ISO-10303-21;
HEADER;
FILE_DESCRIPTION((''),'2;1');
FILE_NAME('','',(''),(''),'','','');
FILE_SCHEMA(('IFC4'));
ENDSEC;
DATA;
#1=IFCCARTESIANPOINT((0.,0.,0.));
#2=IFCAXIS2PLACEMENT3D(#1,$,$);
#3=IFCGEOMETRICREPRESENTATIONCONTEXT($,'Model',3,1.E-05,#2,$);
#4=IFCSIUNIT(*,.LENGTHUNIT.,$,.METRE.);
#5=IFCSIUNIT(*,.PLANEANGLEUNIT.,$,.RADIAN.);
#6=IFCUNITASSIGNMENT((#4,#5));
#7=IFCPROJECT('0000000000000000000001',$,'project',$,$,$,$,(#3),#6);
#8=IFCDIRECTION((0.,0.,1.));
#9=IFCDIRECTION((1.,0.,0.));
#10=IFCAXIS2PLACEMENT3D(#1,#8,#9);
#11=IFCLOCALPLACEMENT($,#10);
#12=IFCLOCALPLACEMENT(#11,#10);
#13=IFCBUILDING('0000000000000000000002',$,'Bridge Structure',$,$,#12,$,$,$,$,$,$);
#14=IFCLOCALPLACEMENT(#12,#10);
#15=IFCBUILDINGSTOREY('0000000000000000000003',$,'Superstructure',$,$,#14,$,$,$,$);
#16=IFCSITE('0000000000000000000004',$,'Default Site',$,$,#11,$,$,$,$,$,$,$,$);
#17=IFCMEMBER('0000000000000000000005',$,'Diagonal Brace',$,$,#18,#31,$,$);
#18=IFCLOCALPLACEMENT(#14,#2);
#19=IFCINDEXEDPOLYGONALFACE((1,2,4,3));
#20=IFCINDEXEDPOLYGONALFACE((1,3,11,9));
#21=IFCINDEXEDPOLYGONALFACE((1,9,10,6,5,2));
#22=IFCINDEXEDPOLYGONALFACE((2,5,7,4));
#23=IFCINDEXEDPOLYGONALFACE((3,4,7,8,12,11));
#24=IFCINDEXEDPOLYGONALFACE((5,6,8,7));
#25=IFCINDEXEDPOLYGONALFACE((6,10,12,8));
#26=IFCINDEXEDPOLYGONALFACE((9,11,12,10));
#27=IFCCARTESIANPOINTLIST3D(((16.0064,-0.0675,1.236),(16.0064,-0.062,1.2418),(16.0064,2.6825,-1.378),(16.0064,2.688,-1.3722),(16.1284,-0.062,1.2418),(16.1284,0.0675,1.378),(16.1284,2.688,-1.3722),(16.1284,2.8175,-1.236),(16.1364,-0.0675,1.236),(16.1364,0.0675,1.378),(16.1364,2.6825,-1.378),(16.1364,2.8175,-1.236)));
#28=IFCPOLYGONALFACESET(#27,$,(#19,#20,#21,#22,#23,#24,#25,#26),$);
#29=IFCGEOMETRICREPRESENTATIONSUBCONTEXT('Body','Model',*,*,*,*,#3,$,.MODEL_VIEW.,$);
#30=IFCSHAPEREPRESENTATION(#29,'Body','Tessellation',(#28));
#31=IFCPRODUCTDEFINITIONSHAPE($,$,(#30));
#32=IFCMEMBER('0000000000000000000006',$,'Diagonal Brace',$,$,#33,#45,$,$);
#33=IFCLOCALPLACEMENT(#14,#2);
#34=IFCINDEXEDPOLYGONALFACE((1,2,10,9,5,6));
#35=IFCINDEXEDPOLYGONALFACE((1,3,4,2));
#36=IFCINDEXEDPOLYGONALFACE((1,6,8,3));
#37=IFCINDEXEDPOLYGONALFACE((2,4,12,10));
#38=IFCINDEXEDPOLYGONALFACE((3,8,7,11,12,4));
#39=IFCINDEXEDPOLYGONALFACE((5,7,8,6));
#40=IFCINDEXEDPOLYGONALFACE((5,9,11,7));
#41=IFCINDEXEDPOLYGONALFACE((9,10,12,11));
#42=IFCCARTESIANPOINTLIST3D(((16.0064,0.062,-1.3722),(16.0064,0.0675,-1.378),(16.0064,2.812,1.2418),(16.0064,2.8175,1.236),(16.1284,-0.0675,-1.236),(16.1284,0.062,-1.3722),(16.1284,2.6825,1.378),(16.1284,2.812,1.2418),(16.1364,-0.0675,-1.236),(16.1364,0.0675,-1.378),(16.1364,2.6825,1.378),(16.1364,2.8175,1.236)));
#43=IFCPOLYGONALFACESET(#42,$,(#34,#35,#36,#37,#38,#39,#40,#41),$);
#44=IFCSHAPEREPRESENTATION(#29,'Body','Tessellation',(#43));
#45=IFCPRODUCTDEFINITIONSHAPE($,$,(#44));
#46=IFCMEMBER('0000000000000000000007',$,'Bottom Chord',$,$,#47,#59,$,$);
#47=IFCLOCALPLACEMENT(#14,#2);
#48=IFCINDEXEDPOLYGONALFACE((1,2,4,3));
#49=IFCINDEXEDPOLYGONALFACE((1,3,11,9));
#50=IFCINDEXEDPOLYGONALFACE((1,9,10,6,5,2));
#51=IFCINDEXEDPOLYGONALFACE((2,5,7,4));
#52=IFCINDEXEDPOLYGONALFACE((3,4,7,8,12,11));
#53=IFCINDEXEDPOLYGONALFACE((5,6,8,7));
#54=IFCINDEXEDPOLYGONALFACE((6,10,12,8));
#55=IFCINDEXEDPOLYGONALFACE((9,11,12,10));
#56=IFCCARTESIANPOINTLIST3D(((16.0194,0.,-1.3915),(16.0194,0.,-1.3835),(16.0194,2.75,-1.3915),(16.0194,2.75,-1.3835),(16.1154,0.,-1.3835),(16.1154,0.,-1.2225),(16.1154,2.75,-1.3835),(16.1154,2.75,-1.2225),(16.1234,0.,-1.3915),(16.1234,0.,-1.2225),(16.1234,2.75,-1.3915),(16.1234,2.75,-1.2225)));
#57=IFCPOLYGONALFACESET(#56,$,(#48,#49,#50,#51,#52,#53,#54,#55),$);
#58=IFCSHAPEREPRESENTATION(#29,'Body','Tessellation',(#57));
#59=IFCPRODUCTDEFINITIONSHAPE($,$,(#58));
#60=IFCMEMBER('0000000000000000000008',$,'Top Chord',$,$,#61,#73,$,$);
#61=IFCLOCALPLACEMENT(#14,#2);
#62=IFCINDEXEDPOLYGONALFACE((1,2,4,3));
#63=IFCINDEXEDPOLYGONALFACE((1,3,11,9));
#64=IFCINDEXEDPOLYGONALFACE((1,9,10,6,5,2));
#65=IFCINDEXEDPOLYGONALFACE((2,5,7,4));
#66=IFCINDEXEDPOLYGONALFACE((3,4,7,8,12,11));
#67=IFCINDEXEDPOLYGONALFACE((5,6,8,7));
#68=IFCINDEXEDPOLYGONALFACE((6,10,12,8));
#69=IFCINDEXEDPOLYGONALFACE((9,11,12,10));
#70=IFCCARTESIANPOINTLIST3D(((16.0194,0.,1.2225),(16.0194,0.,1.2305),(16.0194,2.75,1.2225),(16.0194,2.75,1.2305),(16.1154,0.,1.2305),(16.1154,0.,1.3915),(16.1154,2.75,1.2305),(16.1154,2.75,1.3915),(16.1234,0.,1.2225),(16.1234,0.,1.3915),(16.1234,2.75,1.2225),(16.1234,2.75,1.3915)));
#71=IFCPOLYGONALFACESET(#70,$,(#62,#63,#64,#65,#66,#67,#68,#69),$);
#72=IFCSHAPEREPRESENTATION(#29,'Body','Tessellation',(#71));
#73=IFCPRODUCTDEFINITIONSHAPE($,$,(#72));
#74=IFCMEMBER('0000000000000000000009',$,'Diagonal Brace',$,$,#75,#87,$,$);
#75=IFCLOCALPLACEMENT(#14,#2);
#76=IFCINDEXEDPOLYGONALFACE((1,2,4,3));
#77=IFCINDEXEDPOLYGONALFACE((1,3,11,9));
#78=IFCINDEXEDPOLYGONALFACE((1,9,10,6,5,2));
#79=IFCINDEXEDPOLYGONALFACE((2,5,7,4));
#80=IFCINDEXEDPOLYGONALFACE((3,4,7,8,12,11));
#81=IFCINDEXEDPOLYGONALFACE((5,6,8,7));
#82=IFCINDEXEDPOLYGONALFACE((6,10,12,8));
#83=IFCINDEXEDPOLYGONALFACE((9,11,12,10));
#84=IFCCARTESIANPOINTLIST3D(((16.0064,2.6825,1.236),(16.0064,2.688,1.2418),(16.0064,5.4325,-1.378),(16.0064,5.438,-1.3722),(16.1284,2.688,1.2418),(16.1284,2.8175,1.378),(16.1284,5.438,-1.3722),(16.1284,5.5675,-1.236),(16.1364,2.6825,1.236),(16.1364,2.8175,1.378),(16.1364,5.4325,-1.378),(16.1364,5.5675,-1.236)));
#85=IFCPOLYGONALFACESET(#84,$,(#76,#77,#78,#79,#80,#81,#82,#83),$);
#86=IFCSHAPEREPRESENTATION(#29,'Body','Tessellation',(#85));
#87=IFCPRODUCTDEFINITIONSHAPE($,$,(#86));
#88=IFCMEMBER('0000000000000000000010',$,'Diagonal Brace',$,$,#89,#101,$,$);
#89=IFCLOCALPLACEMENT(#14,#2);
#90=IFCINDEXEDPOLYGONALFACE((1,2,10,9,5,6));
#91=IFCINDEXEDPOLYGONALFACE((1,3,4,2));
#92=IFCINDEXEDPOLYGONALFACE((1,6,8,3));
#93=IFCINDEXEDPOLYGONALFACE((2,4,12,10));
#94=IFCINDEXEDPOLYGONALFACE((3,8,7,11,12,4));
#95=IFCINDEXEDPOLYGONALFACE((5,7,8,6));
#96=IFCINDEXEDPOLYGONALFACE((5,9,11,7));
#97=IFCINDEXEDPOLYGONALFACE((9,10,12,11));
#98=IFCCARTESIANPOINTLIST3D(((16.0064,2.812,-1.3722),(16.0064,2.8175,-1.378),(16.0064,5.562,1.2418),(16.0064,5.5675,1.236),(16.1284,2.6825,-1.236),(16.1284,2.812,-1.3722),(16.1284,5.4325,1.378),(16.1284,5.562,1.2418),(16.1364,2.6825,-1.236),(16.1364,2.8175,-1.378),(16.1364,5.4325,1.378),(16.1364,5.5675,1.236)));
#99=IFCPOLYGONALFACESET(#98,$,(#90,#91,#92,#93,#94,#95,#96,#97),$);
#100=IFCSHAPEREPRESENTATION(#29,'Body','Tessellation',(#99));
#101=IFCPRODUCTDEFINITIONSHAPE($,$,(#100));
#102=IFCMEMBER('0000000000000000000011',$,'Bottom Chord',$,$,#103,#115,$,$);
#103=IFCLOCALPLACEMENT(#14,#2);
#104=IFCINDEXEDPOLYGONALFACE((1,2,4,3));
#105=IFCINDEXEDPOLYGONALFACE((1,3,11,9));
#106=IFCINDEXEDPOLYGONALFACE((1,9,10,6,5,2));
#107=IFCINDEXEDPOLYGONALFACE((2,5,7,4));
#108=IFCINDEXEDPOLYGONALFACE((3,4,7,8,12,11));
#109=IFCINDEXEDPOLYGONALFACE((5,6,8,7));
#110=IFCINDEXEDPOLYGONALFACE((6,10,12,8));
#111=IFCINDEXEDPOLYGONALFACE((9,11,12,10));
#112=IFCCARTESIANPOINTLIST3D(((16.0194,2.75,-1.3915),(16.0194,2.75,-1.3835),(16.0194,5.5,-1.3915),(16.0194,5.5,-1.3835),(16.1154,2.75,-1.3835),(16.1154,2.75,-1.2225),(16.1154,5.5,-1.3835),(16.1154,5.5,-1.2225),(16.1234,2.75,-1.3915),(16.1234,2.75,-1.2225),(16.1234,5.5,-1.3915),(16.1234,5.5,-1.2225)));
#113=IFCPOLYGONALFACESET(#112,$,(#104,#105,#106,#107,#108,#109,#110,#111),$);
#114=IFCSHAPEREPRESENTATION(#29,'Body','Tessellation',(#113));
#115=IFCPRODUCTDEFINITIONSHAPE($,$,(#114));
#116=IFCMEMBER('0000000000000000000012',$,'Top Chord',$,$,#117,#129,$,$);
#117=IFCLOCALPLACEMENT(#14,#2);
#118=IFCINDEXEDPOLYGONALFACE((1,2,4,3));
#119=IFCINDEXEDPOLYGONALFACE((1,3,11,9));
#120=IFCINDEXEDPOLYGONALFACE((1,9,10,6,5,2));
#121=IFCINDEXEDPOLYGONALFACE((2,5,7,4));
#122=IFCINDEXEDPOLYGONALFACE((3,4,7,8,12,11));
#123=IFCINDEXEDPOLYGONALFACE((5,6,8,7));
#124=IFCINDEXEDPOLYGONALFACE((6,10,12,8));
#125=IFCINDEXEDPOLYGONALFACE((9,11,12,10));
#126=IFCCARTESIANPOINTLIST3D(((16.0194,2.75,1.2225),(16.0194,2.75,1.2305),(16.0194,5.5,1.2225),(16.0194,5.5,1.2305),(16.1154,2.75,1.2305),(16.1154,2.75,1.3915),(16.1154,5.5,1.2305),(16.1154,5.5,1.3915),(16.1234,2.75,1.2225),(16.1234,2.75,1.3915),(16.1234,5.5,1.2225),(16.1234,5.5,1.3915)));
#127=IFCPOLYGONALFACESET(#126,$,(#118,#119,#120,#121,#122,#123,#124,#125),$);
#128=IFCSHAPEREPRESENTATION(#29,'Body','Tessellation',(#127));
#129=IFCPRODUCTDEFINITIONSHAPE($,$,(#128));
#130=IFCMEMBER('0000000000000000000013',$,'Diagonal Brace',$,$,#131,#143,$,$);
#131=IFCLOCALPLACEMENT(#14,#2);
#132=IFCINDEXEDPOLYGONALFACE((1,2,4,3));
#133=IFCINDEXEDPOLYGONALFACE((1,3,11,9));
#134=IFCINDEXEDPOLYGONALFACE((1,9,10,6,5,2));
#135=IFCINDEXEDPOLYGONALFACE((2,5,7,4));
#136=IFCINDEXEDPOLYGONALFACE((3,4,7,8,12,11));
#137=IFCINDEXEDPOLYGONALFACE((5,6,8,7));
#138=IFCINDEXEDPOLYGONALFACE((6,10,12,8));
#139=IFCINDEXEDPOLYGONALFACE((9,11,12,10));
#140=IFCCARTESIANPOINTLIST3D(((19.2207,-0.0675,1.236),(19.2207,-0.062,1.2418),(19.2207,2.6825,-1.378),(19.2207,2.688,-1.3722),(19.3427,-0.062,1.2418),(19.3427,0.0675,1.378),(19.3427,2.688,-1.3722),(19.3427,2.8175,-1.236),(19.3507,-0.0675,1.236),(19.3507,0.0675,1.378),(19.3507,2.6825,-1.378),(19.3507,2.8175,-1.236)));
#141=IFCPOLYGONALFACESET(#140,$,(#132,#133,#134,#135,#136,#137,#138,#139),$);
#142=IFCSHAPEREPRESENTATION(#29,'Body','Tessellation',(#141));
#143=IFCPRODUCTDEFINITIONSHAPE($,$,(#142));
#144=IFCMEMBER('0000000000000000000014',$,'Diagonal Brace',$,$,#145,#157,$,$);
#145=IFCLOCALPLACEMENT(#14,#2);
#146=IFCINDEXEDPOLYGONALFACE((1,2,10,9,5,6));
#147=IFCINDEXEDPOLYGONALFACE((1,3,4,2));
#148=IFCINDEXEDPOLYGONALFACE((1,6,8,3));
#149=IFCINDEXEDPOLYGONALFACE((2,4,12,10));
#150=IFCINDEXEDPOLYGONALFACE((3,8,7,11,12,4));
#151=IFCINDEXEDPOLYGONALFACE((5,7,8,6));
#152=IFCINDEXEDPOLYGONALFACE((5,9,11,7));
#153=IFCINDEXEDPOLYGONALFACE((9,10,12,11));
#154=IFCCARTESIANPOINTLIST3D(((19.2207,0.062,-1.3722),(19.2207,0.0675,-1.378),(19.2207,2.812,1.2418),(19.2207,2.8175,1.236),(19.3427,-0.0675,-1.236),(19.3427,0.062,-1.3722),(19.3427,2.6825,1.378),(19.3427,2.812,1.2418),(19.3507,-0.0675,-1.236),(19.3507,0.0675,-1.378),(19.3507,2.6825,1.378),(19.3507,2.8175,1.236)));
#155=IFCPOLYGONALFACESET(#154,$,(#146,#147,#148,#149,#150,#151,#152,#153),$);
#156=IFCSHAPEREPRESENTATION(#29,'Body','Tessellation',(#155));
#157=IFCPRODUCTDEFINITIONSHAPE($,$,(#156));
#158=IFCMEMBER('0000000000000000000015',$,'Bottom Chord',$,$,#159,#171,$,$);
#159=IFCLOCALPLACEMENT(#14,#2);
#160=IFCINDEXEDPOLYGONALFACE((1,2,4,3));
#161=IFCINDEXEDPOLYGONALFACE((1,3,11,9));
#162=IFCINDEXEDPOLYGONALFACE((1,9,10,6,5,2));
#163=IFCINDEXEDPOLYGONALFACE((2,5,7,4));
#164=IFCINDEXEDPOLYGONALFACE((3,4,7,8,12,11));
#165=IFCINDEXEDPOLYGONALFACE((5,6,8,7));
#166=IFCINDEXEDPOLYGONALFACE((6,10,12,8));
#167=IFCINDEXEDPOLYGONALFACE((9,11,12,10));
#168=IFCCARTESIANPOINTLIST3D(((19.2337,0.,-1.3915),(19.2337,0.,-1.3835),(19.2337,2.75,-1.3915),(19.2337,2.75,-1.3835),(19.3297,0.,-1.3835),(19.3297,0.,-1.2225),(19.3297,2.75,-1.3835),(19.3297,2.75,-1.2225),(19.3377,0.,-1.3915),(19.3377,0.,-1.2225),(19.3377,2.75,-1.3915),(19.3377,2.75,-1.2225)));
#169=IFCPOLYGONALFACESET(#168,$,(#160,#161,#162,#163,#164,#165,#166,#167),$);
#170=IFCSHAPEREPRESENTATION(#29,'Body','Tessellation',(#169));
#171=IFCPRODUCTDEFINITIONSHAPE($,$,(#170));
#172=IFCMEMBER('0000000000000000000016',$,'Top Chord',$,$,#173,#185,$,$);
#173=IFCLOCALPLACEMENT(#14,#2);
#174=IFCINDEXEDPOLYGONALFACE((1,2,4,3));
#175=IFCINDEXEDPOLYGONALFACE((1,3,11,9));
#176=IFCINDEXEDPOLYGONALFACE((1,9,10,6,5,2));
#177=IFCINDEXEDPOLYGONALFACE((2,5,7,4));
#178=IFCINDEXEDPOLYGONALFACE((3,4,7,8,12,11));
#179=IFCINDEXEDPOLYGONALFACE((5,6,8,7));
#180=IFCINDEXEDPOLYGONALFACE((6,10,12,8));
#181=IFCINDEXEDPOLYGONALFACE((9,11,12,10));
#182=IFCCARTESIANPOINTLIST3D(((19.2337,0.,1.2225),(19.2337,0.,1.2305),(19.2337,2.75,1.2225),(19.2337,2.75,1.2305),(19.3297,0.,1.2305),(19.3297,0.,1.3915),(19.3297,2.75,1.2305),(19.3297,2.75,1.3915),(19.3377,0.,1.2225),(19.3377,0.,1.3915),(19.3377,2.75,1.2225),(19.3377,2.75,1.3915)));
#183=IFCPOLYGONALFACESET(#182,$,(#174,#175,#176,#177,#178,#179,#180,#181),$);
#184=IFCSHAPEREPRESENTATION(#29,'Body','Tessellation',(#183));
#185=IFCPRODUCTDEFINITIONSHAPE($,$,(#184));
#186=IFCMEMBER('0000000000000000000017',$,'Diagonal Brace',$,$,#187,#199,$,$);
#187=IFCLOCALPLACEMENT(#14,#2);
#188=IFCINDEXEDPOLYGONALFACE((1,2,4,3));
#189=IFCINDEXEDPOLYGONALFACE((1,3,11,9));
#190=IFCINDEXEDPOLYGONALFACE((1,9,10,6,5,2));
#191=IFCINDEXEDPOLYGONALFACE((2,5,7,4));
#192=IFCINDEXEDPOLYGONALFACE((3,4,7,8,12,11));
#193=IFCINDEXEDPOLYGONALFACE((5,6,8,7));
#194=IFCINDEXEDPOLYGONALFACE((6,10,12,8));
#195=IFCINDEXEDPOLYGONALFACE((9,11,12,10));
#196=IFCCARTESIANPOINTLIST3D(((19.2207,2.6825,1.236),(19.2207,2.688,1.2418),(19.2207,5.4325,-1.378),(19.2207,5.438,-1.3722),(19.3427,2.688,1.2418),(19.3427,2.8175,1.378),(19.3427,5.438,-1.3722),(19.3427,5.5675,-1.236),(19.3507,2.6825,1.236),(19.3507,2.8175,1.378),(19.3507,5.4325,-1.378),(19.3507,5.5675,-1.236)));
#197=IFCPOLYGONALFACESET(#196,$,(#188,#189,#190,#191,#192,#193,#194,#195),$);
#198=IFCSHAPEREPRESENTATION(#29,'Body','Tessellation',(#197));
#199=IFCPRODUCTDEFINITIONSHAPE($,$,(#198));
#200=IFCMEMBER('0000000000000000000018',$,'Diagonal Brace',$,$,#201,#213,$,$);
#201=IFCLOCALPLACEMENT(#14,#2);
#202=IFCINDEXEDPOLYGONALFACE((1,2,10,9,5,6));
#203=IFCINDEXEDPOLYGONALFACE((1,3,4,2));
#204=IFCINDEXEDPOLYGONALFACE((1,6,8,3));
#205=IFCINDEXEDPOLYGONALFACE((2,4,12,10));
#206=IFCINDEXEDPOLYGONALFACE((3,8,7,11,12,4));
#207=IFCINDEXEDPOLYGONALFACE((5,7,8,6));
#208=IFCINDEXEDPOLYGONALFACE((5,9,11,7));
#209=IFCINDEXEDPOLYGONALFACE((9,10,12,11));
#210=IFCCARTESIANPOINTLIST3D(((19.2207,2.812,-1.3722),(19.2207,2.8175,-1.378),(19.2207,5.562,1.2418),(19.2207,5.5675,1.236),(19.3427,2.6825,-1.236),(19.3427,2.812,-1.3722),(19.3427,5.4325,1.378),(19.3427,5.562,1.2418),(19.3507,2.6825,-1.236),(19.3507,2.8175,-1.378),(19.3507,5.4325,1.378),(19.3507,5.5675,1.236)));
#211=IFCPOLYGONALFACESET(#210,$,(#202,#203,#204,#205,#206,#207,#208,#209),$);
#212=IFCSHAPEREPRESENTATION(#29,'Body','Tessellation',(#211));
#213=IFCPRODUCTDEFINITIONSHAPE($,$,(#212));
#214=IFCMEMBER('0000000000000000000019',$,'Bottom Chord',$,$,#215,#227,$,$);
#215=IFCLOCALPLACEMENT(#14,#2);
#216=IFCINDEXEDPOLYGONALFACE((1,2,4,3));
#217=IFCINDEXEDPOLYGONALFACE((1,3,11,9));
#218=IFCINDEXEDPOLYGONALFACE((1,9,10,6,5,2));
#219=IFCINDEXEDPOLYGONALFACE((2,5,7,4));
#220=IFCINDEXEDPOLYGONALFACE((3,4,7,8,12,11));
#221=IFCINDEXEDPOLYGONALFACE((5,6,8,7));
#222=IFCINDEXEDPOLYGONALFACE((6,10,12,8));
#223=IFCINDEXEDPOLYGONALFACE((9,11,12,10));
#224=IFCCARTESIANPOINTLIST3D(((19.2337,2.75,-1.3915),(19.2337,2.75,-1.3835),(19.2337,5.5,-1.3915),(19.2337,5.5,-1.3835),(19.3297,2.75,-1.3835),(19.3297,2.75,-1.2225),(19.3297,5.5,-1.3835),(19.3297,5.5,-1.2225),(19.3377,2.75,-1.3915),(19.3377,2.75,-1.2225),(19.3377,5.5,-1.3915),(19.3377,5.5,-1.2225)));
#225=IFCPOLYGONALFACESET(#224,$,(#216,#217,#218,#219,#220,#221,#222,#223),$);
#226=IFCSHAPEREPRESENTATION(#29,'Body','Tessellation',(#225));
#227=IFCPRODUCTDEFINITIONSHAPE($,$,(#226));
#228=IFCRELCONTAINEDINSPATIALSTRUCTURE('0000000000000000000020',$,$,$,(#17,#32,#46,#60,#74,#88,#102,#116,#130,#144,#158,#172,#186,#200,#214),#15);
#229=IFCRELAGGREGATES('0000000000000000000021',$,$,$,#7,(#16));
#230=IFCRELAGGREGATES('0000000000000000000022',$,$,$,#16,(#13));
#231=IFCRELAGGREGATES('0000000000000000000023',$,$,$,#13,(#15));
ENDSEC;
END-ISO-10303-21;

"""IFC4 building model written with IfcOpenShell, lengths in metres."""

from ifc_helpers import new_model, si_unit, frame, origin, origin_with_axes, origin_2d_with_axis, place, context, subcontext, project, spatial, l_section, extrude, element, save


model = new_model("IFC4")

# Units and contexts
model_context = context("Model", 3, precision=1e-05, world=origin())
body_context = subcontext(model_context, "Body", "Model", "MODEL_VIEW")
ifc_project = project(units=[si_unit("LENGTHUNIT", "METRE"), si_unit("PLANEANGLEUNIT", "RADIAN")], contexts=[model_context])

# Site, building, storey
site_placement = place(None, origin_with_axes())
site = spatial("IfcSite", under=ifc_project, at=site_placement, Name="Default Site")
building_placement = place(site_placement, origin_with_axes())
building = spatial("IfcBuilding", under=site, at=building_placement, Name="Bridge Structure")
storey_placement = place(building_placement, origin_with_axes())
storey = spatial("IfcBuildingStorey", under=building, at=storey_placement, Name="Superstructure")

# Members
for number, where, z_axis, x_axis, name in (
    (1, (16.0714, 0.0, 1.307), (0.0, 0.724802, -0.688957), (-1.0, 0.0, 0.0), "Diagonal Brace"),
    (2, (16.0714, 0.0, -1.307), (0.0, 0.724802, 0.688957), (-1.0, 0.0, 0.0), "Diagonal Brace"),
):
    element("IfcMember", number, at=place(storey_placement, frame(where, z_axis=z_axis, x_axis=x_axis)), inside=storey, Name=name, context=body_context, shape_type="SweptSolid", body=[
        extrude(l_section(Depth=0.196, Width=0.13, Thickness=0.008, at=origin_2d_with_axis()), origin_with_axes(), (0.0, 0.0, 1.0), 3.7941),
    ])
for number, where, z_axis, x_axis, name in (
    (3, (16.0714, 0.0, -1.307), (0.0, 1.0, 0.0), (-1.0, 0.0, 0.0), "Bottom Chord"),
    (4, (16.0714, 0.0, 1.307), (0.0, 1.0, 0.0), (-1.0, 0.0, 0.0), "Top Chord"),
):
    element("IfcMember", number, at=place(storey_placement, frame(where, z_axis=z_axis, x_axis=x_axis)), inside=storey, Name=name, context=body_context, shape_type="SweptSolid", body=[
        extrude(l_section(Depth=0.169, Width=0.104, Thickness=0.008, at=origin_2d_with_axis()), origin_with_axes(), (0.0, 0.0, 1.0), 2.75),
    ])
for number, where, z_axis, x_axis, name in (
    (5, (16.0714, 2.75, 1.307), (0.0, 0.724802, -0.688957), (-1.0, 0.0, 0.0), "Diagonal Brace"),
    (6, (16.0714, 2.75, -1.307), (0.0, 0.724802, 0.688957), (-1.0, 0.0, 0.0), "Diagonal Brace"),
):
    element("IfcMember", number, at=place(storey_placement, frame(where, z_axis=z_axis, x_axis=x_axis)), inside=storey, Name=name, context=body_context, shape_type="SweptSolid", body=[
        extrude(l_section(Depth=0.196, Width=0.13, Thickness=0.008, at=origin_2d_with_axis()), origin_with_axes(), (0.0, 0.0, 1.0), 3.7941),
    ])
for number, where, z_axis, x_axis, name in (
    (7, (16.0714, 2.75, -1.307), (0.0, 1.0, 0.0), (-1.0, 0.0, 0.0), "Bottom Chord"),
    (8, (16.0714, 2.75, 1.307), (0.0, 1.0, 0.0), (-1.0, 0.0, 0.0), "Top Chord"),
):
    element("IfcMember", number, at=place(storey_placement, frame(where, z_axis=z_axis, x_axis=x_axis)), inside=storey, Name=name, context=body_context, shape_type="SweptSolid", body=[
        extrude(l_section(Depth=0.169, Width=0.104, Thickness=0.008, at=origin_2d_with_axis()), origin_with_axes(), (0.0, 0.0, 1.0), 2.75),
    ])
for number, where, z_axis, x_axis, name in (
    (9, (19.2857, 0.0, 1.307), (0.0, 0.724802, -0.688957), (-1.0, 0.0, 0.0), "Diagonal Brace"),
    (10, (19.2857, 0.0, -1.307), (0.0, 0.724802, 0.688957), (-1.0, 0.0, 0.0), "Diagonal Brace"),
):
    element("IfcMember", number, at=place(storey_placement, frame(where, z_axis=z_axis, x_axis=x_axis)), inside=storey, Name=name, context=body_context, shape_type="SweptSolid", body=[
        extrude(l_section(Depth=0.196, Width=0.13, Thickness=0.008, at=origin_2d_with_axis()), origin_with_axes(), (0.0, 0.0, 1.0), 3.7941),
    ])
for number, where, z_axis, x_axis, name in (
    (11, (19.2857, 0.0, -1.307), (0.0, 1.0, 0.0), (-1.0, 0.0, 0.0), "Bottom Chord"),
    (12, (19.2857, 0.0, 1.307), (0.0, 1.0, 0.0), (-1.0, 0.0, 0.0), "Top Chord"),
):
    element("IfcMember", number, at=place(storey_placement, frame(where, z_axis=z_axis, x_axis=x_axis)), inside=storey, Name=name, context=body_context, shape_type="SweptSolid", body=[
        extrude(l_section(Depth=0.169, Width=0.104, Thickness=0.008, at=origin_2d_with_axis()), origin_with_axes(), (0.0, 0.0, 1.0), 2.75),
    ])
for number, where, z_axis, x_axis, name in (
    (13, (19.2857, 2.75, 1.307), (0.0, 0.724802, -0.688957), (-1.0, 0.0, 0.0), "Diagonal Brace"),
    (14, (19.2857, 2.75, -1.307), (0.0, 0.724802, 0.688957), (-1.0, 0.0, 0.0), "Diagonal Brace"),
):
    element("IfcMember", number, at=place(storey_placement, frame(where, z_axis=z_axis, x_axis=x_axis)), inside=storey, Name=name, context=body_context, shape_type="SweptSolid", body=[
        extrude(l_section(Depth=0.196, Width=0.13, Thickness=0.008, at=origin_2d_with_axis()), origin_with_axes(), (0.0, 0.0, 1.0), 3.7941),
    ])
for number, where, z_axis, x_axis, name in (
    (15, (19.2857, 2.75, -1.307), (0.0, 1.0, 0.0), (-1.0, 0.0, 0.0), "Bottom Chord"),
):
    element("IfcMember", number, at=place(storey_placement, frame(where, z_axis=z_axis, x_axis=x_axis)), inside=storey, Name=name, context=body_context, shape_type="SweptSolid", body=[
        extrude(l_section(Depth=0.169, Width=0.104, Thickness=0.008, at=origin_2d_with_axis()), origin_with_axes(), (0.0, 0.0, 1.0), 2.75),
    ])

save(model, "model.ifc")
